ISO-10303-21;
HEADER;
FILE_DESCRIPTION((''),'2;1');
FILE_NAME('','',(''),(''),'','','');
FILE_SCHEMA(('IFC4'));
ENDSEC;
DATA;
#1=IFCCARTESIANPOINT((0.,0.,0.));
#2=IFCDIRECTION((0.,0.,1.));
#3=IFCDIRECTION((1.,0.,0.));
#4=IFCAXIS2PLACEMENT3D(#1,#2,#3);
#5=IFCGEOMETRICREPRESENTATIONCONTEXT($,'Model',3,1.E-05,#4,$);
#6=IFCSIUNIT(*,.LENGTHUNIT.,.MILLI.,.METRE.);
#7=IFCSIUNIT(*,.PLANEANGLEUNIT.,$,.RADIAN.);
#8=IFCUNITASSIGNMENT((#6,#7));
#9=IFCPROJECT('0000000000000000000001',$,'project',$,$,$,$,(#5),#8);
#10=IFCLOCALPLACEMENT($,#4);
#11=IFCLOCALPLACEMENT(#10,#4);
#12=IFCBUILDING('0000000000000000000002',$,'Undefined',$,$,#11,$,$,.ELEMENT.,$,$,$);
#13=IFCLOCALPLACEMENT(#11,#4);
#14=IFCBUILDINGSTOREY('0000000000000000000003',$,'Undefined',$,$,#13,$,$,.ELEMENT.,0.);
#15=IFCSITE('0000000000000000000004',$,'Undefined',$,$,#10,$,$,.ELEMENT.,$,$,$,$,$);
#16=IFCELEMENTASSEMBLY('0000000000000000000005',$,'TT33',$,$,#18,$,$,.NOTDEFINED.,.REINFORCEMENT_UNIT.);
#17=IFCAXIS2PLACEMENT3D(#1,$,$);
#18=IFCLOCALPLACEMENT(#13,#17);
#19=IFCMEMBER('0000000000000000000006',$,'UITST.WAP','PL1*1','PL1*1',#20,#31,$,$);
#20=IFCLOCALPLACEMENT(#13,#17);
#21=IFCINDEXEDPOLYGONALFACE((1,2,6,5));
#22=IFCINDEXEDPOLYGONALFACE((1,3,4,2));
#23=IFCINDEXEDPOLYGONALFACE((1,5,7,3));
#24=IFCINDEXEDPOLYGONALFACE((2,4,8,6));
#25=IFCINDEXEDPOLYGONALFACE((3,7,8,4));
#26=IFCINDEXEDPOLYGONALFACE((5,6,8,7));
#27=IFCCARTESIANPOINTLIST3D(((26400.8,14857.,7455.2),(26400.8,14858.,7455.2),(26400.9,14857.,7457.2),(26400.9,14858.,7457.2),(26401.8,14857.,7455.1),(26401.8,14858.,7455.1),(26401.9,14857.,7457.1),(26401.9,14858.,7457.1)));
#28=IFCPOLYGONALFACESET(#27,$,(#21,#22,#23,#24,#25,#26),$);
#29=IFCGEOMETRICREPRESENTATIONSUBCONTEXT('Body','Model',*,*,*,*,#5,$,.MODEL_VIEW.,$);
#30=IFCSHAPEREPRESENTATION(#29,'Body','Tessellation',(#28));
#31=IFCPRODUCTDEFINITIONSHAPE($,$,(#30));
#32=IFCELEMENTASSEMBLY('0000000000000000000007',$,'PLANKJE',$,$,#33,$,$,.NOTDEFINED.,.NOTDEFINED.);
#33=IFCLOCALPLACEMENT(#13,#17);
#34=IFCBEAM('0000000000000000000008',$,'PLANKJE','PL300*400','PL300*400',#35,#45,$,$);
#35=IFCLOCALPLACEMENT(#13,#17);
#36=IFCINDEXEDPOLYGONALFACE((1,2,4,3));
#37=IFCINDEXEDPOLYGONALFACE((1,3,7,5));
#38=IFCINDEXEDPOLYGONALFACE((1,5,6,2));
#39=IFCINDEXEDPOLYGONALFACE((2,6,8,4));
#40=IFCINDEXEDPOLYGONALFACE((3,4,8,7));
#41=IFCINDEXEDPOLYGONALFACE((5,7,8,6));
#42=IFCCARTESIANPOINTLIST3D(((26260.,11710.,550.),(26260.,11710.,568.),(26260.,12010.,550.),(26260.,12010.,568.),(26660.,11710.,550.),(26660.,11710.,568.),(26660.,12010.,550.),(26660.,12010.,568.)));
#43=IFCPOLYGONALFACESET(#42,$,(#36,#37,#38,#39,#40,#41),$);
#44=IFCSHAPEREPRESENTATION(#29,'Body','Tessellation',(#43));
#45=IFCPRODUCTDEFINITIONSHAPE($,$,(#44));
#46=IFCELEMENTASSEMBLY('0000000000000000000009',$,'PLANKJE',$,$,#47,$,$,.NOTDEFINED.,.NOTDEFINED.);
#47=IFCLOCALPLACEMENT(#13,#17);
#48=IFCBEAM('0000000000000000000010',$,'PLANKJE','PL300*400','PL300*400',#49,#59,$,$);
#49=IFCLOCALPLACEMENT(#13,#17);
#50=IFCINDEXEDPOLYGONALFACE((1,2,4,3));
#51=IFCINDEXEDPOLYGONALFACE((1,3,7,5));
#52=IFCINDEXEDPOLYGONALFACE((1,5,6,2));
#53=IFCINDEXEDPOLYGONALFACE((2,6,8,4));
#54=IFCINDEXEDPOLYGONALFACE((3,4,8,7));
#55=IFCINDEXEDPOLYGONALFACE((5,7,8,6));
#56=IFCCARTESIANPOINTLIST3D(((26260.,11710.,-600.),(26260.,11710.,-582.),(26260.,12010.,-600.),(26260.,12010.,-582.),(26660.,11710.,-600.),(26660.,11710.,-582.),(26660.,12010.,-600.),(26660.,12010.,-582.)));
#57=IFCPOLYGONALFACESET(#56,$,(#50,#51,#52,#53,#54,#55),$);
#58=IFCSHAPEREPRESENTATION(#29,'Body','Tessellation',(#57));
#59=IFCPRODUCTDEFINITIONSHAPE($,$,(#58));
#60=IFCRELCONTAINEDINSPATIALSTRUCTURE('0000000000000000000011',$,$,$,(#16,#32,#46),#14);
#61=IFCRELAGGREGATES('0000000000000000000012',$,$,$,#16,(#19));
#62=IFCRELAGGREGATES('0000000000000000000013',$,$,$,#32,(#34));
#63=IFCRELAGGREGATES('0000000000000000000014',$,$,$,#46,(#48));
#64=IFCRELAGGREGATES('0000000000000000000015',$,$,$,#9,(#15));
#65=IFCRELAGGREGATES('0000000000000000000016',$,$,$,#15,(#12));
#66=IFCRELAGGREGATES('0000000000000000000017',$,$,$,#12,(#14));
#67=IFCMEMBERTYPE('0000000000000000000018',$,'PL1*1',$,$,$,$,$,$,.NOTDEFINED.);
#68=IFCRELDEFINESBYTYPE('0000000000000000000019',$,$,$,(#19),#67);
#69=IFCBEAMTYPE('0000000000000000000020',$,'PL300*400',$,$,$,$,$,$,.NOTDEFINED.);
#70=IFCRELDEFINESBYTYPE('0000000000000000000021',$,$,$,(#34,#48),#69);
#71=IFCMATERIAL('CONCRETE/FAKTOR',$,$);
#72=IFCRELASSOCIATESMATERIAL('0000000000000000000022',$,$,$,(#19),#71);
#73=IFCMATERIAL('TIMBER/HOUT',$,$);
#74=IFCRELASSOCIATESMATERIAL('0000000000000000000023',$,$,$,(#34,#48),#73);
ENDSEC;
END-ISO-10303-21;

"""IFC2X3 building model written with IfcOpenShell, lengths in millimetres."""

from ifc_helpers import new_model, si_unit, frame, frame_2d, origin_with_axes, place, context, subcontext, project, spatial, rectangle, extrude, material, type_object, element, aggregate, save


model = new_model("IFC2X3")

# Units and contexts
model_context = context("Model", 3, precision=1e-05, world=origin_with_axes())
body_context = subcontext(model_context, "Body", "Model", "MODEL_VIEW")
ifc_project = project(units=[si_unit("LENGTHUNIT", "METRE", prefix="MILLI"), si_unit("PLANEANGLEUNIT", "RADIAN")], contexts=[model_context])

# Site, building, storey
site_placement = place(None, origin_with_axes())
site = spatial("IfcSite", under=ifc_project, at=site_placement, Name="Undefined", CompositionType="ELEMENT")
building_placement = place(site_placement, origin_with_axes())
building = spatial("IfcBuilding", under=site, at=building_placement, Name="Undefined", CompositionType="ELEMENT")
storey_placement = place(building_placement, origin_with_axes())
storey = spatial("IfcBuildingStorey", under=building, at=storey_placement, Name="Undefined", CompositionType="ELEMENT", Elevation=0.0)

# Shared definitions
ifc_material_1 = material(Name="CONCRETE/FAKTOR")

# Element assembly
assembly_1_placement = place(storey_placement, origin_with_axes())
assembly_1 = element("IfcElementAssembly", 1, at=assembly_1_placement, inside=storey, Name="TT33", AssemblyPlace="NOTDEFINED", PredefinedType="REINFORCEMENT_UNIT")

# Member
member_type = type_object("IfcMemberType", Name="PL1*1", PredefinedType="NOTDEFINED")
member_1_placement = place(assembly_1_placement, frame((26401.3, 14857.5, 7455.1), z_axis=(0.0, -1.0, 0.0), x_axis=(0.031107, 0.0, 0.999516)))
member_1 = element("IfcMember", 2, at=member_1_placement, type_object=member_type, material=ifc_material_1, Name="UITST.WAP", Description="PL1*1", ObjectType="PL1*1", context=body_context, shape_type="SweptSolid", body=[
    extrude(rectangle(XDim=1.0, YDim=1.0, at=frame_2d((0.0, 0.0), x_axis=(1.0, 0.0))), frame((2.0, 0.0, 0.0), z_axis=(-1.0, 0.0, 0.0), x_axis=(0.0, -1.0, 0.0)), (0.0, 0.0, 1.0), 2.0),
])
aggregate(assembly_1, [member_1])

# Element assemblies, beams
assembly_2_placement = place(storey_placement, origin_with_axes())
assembly_2 = element("IfcElementAssembly", 3, at=assembly_2_placement, inside=storey, Name="PLANKJE", AssemblyPlace="NOTDEFINED", PredefinedType="NOTDEFINED")
ifc_material_2 = material(Name="TIMBER/HOUT")
beam_type_1 = type_object("IfcBeamType", Name="PL300*400", PredefinedType="NOTDEFINED")
beam_1_placement = place(assembly_2_placement, frame((26460.0, 11860.0, 550.0), z_axis=(-1.0, 0.0, 0.0), x_axis=(0.0, 0.0, 1.0)))
beam_1 = element("IfcBeam", 4, at=beam_1_placement, type_object=beam_type_1, material=ifc_material_2, Name="PLANKJE", Description="PL300*400", ObjectType="PL300*400", context=body_context, shape_type="SweptSolid", body=[
    extrude(rectangle(XDim=300.0, YDim=400.0, at=frame_2d((0.0, 0.0), x_axis=(1.0, 0.0))), frame((18.0, 0.0, 0.0), z_axis=(-1.0, 0.0, 0.0), x_axis=(0.0, -1.0, 0.0)), (0.0, 0.0, 1.0), 18.0),
])
aggregate(assembly_2, [beam_1])
assembly_3_placement = place(storey_placement, origin_with_axes())
assembly_3 = element("IfcElementAssembly", 5, at=assembly_3_placement, inside=storey, Name="PLANKJE", AssemblyPlace="NOTDEFINED", PredefinedType="NOTDEFINED")
beam_2_placement = place(assembly_3_placement, frame((26460.0, 11860.0, -600.0), z_axis=(-1.0, 0.0, 0.0), x_axis=(0.0, 0.0, 1.0)))
beam_2 = element("IfcBeam", 6, at=beam_2_placement, type_object=beam_type_1, material=ifc_material_2, Name="PLANKJE", Description="PL300*400", ObjectType="PL300*400", context=body_context, shape_type="SweptSolid", body=[
    extrude(rectangle(XDim=300.0, YDim=400.0, at=frame_2d((0.0, 0.0), x_axis=(1.0, 0.0))), frame((18.0, 0.0, 0.0), z_axis=(-1.0, 0.0, 0.0), x_axis=(0.0, -1.0, 0.0)), (0.0, 0.0, 1.0), 18.0),
])
aggregate(assembly_3, [beam_2])

save(model, "model.ifc")
